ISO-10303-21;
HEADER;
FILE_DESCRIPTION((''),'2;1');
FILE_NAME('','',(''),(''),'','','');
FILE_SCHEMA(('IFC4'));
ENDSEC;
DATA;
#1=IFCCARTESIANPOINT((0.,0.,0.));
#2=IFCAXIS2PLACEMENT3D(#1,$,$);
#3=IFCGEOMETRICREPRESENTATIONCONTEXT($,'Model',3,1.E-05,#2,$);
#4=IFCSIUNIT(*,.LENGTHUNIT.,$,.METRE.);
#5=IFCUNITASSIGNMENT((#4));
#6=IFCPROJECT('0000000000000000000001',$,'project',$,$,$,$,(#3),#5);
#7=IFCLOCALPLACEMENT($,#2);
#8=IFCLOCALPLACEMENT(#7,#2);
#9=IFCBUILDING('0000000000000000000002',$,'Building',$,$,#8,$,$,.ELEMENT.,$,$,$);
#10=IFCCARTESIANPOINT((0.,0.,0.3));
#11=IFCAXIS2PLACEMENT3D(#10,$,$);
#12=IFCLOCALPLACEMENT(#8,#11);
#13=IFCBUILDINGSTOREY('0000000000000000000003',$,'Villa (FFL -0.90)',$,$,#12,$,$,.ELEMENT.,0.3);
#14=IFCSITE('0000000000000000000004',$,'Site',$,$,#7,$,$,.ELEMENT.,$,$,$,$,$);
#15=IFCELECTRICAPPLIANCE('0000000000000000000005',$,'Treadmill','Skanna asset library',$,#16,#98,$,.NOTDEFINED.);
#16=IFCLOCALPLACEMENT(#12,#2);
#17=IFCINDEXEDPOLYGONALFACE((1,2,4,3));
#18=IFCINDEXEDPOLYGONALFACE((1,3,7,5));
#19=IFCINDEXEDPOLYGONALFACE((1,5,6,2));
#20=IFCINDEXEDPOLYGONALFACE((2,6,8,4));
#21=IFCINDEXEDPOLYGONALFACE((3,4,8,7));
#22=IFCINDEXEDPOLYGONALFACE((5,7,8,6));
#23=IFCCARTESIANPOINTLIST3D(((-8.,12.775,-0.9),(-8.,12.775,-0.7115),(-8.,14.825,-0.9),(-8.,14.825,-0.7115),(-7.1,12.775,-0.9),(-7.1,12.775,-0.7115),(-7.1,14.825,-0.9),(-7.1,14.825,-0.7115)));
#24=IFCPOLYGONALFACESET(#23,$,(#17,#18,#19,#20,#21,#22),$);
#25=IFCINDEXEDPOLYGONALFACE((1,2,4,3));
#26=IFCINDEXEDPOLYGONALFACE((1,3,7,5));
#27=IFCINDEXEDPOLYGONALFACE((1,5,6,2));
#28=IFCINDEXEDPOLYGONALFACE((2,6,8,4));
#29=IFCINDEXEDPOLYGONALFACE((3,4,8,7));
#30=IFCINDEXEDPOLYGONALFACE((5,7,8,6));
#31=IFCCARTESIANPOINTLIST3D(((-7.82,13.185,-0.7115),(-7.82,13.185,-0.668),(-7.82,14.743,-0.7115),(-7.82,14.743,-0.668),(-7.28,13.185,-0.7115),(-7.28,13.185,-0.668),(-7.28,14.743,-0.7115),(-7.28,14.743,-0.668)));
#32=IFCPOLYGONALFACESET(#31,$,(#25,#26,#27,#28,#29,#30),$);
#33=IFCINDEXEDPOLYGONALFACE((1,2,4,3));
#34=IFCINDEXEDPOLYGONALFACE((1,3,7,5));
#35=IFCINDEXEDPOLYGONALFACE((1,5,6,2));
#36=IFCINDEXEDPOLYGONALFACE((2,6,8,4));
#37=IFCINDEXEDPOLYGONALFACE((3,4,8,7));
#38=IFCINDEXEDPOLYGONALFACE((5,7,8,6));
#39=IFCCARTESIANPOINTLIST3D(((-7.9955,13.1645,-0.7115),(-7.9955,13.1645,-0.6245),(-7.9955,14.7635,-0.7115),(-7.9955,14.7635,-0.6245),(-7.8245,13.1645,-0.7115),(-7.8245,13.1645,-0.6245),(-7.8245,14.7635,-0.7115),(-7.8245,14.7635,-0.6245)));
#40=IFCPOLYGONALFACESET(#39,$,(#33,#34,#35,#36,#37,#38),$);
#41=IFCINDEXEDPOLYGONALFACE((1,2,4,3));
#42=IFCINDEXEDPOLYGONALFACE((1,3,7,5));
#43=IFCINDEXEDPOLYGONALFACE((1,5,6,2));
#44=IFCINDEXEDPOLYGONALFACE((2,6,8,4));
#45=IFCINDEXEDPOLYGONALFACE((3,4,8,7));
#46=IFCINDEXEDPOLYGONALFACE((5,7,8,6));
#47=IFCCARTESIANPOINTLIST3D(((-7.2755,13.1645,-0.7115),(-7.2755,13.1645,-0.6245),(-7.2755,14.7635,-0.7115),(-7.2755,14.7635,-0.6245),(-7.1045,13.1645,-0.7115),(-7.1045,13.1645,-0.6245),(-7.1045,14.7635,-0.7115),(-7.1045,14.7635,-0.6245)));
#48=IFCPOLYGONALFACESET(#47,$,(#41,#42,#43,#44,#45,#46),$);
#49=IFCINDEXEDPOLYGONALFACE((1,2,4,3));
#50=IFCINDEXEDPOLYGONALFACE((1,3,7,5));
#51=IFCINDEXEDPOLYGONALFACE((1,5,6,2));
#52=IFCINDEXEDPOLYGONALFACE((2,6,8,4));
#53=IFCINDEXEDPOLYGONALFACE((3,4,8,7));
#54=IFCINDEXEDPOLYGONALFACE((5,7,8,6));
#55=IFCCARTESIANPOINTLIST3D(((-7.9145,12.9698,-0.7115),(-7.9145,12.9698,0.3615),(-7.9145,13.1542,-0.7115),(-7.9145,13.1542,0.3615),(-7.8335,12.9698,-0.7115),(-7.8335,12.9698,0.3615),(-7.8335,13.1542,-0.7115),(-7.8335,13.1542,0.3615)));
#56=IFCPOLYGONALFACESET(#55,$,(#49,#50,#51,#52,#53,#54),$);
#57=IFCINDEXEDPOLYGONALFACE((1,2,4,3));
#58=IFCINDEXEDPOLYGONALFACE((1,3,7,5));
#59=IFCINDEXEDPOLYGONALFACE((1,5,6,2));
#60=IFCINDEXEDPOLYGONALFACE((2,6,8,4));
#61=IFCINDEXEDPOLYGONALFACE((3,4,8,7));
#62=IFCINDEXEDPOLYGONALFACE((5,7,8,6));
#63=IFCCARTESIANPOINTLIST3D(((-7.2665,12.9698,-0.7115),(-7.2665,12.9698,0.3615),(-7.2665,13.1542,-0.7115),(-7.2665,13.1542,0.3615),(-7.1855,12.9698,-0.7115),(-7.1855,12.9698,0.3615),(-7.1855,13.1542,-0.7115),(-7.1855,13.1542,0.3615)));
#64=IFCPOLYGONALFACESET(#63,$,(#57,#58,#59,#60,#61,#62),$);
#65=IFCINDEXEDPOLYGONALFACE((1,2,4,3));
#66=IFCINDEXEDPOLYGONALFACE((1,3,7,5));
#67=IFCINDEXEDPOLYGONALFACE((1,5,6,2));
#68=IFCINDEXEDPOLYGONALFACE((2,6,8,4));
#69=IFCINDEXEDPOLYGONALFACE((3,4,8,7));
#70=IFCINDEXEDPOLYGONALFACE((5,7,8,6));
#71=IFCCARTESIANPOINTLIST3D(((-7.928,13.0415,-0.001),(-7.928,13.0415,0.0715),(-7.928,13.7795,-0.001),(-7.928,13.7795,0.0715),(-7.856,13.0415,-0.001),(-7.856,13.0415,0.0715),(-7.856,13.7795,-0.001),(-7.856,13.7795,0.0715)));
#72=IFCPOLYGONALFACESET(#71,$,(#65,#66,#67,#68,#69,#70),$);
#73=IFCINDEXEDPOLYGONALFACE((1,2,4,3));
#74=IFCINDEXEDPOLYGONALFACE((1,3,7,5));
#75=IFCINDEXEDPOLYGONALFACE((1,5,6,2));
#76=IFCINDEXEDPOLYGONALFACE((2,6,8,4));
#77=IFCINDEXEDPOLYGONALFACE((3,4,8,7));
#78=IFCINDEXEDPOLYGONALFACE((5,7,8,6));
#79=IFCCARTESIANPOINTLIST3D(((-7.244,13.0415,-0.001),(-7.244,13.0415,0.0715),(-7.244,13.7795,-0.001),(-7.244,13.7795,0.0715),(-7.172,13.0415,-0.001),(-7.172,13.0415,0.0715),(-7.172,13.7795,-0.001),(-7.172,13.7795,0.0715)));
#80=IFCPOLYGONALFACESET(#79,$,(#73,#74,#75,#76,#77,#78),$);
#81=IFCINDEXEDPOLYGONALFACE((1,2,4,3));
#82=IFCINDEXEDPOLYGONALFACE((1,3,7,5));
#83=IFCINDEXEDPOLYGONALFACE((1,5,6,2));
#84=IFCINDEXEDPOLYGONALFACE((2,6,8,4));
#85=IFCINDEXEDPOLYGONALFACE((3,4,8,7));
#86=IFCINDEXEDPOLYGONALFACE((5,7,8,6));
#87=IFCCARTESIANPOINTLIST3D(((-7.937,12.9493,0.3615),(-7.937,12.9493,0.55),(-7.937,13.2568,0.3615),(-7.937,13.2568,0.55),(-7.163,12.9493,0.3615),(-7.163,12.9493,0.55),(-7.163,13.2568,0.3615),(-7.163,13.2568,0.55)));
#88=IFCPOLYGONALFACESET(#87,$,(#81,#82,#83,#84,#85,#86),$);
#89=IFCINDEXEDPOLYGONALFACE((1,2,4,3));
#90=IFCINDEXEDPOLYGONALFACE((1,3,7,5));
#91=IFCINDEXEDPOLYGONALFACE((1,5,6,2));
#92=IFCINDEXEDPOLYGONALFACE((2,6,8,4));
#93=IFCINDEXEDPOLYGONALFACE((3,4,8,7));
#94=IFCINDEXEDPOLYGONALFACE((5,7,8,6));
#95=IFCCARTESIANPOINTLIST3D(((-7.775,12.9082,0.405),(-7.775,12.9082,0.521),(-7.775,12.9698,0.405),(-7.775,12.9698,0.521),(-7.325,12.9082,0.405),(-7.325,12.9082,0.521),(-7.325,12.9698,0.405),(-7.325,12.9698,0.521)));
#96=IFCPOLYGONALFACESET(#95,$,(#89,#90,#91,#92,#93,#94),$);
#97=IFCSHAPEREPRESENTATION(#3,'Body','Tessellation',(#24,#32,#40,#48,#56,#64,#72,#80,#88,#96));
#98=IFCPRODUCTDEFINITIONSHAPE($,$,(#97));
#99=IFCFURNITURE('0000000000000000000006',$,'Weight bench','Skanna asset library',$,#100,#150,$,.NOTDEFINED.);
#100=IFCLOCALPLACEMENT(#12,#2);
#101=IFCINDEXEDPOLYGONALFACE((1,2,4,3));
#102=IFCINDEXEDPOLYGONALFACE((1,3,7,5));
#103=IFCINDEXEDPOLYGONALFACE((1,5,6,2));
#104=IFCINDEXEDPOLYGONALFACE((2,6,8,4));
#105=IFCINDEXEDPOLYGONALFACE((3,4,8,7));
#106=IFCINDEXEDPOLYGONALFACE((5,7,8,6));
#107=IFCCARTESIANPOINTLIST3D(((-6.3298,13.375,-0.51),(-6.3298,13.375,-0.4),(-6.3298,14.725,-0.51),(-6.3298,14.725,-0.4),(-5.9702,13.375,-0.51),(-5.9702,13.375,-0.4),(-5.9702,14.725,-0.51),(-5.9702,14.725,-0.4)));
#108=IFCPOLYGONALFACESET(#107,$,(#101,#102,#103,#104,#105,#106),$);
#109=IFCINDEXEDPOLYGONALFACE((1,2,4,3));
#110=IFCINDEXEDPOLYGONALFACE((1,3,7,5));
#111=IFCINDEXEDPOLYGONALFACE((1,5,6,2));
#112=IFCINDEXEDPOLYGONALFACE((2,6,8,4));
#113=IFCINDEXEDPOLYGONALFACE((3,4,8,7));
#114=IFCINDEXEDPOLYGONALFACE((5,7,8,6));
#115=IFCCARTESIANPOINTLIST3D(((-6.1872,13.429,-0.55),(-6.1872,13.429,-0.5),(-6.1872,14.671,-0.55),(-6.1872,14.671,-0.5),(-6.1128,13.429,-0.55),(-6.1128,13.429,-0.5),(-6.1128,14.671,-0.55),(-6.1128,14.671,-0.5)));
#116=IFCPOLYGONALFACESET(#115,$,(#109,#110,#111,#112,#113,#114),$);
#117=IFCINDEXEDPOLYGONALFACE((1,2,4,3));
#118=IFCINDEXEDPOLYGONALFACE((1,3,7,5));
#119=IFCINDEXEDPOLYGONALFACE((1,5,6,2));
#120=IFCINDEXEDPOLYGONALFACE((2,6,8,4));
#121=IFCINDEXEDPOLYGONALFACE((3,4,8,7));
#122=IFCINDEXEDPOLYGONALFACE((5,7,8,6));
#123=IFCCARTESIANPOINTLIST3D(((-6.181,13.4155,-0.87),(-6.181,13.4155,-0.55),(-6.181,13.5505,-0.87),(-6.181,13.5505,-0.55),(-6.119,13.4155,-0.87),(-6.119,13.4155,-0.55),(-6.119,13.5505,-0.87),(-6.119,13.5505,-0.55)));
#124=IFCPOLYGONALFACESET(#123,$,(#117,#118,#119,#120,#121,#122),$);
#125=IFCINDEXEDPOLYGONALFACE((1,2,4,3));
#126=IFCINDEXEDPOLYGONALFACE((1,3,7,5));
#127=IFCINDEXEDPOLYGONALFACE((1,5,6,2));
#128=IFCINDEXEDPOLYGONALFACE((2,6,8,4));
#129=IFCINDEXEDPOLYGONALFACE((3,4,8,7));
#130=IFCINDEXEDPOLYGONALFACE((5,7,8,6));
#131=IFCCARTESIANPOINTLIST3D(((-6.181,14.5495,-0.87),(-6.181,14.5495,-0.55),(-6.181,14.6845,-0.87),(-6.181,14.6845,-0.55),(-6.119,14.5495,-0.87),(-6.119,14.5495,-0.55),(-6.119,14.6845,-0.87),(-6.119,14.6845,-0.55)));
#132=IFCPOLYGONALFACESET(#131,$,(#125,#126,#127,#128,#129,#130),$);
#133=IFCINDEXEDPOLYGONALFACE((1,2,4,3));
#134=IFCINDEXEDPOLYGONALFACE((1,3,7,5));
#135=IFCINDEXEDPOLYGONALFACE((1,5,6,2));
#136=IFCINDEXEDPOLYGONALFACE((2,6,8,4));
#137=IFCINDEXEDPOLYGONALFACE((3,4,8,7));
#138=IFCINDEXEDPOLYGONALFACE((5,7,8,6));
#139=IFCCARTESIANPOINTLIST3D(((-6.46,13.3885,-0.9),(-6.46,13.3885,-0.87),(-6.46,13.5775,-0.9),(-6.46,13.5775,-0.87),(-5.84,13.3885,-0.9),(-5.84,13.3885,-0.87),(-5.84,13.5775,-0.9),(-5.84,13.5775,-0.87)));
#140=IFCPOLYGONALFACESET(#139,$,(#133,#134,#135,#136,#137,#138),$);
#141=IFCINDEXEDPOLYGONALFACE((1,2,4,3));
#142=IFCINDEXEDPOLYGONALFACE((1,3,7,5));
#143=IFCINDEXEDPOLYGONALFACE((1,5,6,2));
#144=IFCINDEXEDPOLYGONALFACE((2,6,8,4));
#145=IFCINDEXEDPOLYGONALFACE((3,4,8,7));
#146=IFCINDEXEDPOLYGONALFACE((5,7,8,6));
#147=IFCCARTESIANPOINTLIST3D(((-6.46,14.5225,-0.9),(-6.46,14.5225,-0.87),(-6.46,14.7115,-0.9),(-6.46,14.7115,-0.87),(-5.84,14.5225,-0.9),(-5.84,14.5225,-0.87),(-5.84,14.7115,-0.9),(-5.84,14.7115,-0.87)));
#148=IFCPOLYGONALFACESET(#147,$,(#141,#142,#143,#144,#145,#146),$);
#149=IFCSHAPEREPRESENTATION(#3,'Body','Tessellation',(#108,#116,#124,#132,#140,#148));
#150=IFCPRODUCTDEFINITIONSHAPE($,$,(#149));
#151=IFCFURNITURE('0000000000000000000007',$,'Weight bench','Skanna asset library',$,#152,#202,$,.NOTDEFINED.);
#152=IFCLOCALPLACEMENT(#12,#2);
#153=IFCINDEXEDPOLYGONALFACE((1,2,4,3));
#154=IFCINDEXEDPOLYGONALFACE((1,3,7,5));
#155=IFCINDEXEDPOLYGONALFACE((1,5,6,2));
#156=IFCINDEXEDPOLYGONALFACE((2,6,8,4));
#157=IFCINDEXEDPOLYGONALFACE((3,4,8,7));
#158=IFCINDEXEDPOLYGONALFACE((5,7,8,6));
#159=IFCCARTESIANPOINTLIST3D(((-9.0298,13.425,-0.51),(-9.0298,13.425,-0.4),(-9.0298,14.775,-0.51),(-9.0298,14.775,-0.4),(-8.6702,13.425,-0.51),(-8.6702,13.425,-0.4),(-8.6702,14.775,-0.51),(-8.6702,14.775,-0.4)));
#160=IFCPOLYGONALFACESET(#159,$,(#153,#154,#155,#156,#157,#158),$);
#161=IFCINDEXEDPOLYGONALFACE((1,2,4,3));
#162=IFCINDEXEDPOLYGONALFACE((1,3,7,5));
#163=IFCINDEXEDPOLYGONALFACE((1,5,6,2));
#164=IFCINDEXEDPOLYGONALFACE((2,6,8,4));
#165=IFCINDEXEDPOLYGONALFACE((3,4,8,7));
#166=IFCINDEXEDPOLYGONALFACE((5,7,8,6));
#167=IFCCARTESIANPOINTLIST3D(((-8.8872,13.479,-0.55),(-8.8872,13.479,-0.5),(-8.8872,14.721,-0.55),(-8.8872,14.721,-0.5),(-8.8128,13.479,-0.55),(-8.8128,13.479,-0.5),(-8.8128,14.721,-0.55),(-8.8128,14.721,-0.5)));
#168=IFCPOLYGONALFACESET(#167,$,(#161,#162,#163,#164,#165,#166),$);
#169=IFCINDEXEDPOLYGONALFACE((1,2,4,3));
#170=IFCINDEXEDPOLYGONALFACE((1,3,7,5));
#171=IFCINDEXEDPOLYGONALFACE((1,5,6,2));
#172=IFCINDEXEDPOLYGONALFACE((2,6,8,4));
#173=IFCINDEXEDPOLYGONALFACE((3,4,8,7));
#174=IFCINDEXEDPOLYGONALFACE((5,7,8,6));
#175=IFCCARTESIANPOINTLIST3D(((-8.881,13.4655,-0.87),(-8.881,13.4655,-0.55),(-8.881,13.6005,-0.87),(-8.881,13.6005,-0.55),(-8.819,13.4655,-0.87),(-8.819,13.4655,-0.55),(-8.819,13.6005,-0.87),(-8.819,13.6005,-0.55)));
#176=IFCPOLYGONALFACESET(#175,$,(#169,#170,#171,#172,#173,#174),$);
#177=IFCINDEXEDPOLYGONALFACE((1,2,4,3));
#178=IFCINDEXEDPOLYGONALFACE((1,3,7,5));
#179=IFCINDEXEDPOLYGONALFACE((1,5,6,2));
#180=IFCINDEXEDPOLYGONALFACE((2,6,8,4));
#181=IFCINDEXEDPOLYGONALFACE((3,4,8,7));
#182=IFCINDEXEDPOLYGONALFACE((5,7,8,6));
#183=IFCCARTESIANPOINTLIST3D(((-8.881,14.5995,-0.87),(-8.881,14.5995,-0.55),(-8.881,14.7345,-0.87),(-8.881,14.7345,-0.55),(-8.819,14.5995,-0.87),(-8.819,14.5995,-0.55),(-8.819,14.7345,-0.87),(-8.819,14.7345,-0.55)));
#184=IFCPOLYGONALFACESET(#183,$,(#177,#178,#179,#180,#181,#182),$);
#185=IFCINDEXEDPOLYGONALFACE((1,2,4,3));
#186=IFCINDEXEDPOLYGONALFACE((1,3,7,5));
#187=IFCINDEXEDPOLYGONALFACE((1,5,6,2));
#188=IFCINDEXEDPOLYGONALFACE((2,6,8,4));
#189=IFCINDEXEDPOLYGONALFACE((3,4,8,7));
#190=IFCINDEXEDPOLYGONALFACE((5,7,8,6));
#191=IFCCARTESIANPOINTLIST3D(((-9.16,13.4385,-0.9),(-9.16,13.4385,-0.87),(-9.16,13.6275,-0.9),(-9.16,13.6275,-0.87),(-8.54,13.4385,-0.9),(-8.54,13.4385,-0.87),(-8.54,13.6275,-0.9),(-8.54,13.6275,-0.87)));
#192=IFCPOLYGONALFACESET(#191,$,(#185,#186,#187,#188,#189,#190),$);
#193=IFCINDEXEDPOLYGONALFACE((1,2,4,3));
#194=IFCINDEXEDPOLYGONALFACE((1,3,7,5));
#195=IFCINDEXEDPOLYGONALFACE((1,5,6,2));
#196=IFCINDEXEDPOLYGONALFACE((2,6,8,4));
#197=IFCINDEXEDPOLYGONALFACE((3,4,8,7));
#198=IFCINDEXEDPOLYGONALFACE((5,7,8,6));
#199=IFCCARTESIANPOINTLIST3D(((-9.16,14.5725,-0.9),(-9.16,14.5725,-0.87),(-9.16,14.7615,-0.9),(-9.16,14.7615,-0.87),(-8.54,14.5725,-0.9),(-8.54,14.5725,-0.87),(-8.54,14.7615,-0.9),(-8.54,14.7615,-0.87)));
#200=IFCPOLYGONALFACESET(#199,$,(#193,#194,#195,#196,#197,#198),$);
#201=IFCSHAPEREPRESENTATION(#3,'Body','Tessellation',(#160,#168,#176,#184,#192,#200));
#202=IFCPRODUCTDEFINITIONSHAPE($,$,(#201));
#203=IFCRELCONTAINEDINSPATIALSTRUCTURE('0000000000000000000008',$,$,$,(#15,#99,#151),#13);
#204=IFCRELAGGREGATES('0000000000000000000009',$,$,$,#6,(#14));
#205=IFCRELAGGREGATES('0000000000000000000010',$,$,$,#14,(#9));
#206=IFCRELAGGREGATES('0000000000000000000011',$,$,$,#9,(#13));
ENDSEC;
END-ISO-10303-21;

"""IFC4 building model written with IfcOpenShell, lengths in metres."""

from ifc_helpers import new_model, si_unit, frame, frame_2d, origin, origin_2d, place, context, project, spatial, rectangle, extrude, element, save


model = new_model("IFC4")

# Units and contexts
model_context = context("Model", 3, precision=1e-05, world=origin())
ifc_project = project(units=[si_unit("LENGTHUNIT", "METRE")], contexts=[model_context])

# Site, building, storey
site_placement = place(None, origin())
site = spatial("IfcSite", under=ifc_project, at=site_placement, Name="Site", CompositionType="ELEMENT")
building_placement = place(site_placement, origin())
building = spatial("IfcBuilding", under=site, at=building_placement, Name="Building", CompositionType="ELEMENT")
storey_placement = place(building_placement, frame((0.0, 0.0, 0.3)))
storey = spatial("IfcBuildingStorey", under=building, at=storey_placement, Name="Villa (FFL -0.90)", CompositionType="ELEMENT", Elevation=0.3)

# Electric appliance
electric_appliance_placement = place(storey_placement, frame((-7.55, 13.8, -0.9), z_axis=(0.0, 0.0, 1.0), x_axis=(1.0, 0.0, 0.0)))
element("IfcElectricAppliance", 1, at=electric_appliance_placement, inside=storey, Name="Treadmill", Description="Skanna asset library", PredefinedType="NOTDEFINED", context=model_context, shape_type="SweptSolid", body=[
    extrude(rectangle(XDim=0.9, YDim=2.05, at=origin_2d()), origin(), (0.0, 0.0, 1.0), 0.1885),
    extrude(rectangle(XDim=0.54, YDim=1.558, at=frame_2d((0.0, 0.164))), frame((0.0, 0.0, 0.1885)), (0.0, 0.0, 1.0), 0.0435),
    extrude(rectangle(XDim=0.171, YDim=1.599, at=frame_2d((-0.36, 0.164))), frame((0.0, 0.0, 0.1885)), (0.0, 0.0, 1.0), 0.087),
    extrude(rectangle(XDim=0.171, YDim=1.599, at=frame_2d((0.36, 0.164))), frame((0.0, 0.0, 0.1885)), (0.0, 0.0, 1.0), 0.087),
    extrude(rectangle(XDim=0.081, YDim=0.1845, at=frame_2d((-0.324, -0.738))), frame((0.0, 0.0, 0.1885)), (0.0, 0.0, 1.0), 1.073),
    extrude(rectangle(XDim=0.081, YDim=0.1845, at=frame_2d((0.324, -0.738))), frame((0.0, 0.0, 0.1885)), (0.0, 0.0, 1.0), 1.073),
    extrude(rectangle(XDim=0.072, YDim=0.738, at=frame_2d((-0.342, -0.3895))), frame((0.0, 0.0, 0.899)), (0.0, 0.0, 1.0), 0.0725),
    extrude(rectangle(XDim=0.072, YDim=0.738, at=frame_2d((0.342, -0.3895))), frame((0.0, 0.0, 0.899)), (0.0, 0.0, 1.0), 0.0725),
    extrude(rectangle(XDim=0.774, YDim=0.3075, at=frame_2d((0.0, -0.697))), frame((0.0, 0.0, 1.2615)), (0.0, 0.0, 1.0), 0.1885),
    extrude(rectangle(XDim=0.45, YDim=0.0615, at=frame_2d((0.0, -0.861))), frame((0.0, 0.0, 1.305)), (0.0, 0.0, 1.0), 0.116),
])

# Furniture
for number, where, z_axis, x_axis, name in (
    (2, (-6.15, 14.05, -0.9), (0.0, 0.0, 1.0), (1.0, 0.0, 0.0), "Weight bench"),
    (3, (-8.85, 14.1, -0.9), (0.0, 0.0, 1.0), (1.0, 0.0, 0.0), "Weight bench"),
):
    element("IfcFurniture", number, at=place(storey_placement, frame(where, z_axis=z_axis, x_axis=x_axis)), inside=storey, Name=name, Description="Skanna asset library", PredefinedType="NOTDEFINED", context=model_context, shape_type="SweptSolid", body=[
        extrude(rectangle(XDim=0.3596, YDim=1.35, at=origin_2d()), frame((0.0, 0.0, 0.39)), (0.0, 0.0, 1.0), 0.11),
        extrude(rectangle(XDim=0.0744, YDim=1.242, at=origin_2d()), frame((0.0, 0.0, 0.35)), (0.0, 0.0, 1.0), 0.05),
        extrude(rectangle(XDim=0.062, YDim=0.135, at=frame_2d((0.0, -0.567))), frame((0.0, 0.0, 0.03)), (0.0, 0.0, 1.0), 0.32),
        extrude(rectangle(XDim=0.062, YDim=0.135, at=frame_2d((0.0, 0.567))), frame((0.0, 0.0, 0.03)), (0.0, 0.0, 1.0), 0.32),
        extrude(rectangle(XDim=0.62, YDim=0.189, at=frame_2d((0.0, -0.567))), origin(), (0.0, 0.0, 1.0), 0.03),
        extrude(rectangle(XDim=0.62, YDim=0.189, at=frame_2d((0.0, 0.567))), origin(), (0.0, 0.0, 1.0), 0.03),
    ])

save(model, "model.ifc")
